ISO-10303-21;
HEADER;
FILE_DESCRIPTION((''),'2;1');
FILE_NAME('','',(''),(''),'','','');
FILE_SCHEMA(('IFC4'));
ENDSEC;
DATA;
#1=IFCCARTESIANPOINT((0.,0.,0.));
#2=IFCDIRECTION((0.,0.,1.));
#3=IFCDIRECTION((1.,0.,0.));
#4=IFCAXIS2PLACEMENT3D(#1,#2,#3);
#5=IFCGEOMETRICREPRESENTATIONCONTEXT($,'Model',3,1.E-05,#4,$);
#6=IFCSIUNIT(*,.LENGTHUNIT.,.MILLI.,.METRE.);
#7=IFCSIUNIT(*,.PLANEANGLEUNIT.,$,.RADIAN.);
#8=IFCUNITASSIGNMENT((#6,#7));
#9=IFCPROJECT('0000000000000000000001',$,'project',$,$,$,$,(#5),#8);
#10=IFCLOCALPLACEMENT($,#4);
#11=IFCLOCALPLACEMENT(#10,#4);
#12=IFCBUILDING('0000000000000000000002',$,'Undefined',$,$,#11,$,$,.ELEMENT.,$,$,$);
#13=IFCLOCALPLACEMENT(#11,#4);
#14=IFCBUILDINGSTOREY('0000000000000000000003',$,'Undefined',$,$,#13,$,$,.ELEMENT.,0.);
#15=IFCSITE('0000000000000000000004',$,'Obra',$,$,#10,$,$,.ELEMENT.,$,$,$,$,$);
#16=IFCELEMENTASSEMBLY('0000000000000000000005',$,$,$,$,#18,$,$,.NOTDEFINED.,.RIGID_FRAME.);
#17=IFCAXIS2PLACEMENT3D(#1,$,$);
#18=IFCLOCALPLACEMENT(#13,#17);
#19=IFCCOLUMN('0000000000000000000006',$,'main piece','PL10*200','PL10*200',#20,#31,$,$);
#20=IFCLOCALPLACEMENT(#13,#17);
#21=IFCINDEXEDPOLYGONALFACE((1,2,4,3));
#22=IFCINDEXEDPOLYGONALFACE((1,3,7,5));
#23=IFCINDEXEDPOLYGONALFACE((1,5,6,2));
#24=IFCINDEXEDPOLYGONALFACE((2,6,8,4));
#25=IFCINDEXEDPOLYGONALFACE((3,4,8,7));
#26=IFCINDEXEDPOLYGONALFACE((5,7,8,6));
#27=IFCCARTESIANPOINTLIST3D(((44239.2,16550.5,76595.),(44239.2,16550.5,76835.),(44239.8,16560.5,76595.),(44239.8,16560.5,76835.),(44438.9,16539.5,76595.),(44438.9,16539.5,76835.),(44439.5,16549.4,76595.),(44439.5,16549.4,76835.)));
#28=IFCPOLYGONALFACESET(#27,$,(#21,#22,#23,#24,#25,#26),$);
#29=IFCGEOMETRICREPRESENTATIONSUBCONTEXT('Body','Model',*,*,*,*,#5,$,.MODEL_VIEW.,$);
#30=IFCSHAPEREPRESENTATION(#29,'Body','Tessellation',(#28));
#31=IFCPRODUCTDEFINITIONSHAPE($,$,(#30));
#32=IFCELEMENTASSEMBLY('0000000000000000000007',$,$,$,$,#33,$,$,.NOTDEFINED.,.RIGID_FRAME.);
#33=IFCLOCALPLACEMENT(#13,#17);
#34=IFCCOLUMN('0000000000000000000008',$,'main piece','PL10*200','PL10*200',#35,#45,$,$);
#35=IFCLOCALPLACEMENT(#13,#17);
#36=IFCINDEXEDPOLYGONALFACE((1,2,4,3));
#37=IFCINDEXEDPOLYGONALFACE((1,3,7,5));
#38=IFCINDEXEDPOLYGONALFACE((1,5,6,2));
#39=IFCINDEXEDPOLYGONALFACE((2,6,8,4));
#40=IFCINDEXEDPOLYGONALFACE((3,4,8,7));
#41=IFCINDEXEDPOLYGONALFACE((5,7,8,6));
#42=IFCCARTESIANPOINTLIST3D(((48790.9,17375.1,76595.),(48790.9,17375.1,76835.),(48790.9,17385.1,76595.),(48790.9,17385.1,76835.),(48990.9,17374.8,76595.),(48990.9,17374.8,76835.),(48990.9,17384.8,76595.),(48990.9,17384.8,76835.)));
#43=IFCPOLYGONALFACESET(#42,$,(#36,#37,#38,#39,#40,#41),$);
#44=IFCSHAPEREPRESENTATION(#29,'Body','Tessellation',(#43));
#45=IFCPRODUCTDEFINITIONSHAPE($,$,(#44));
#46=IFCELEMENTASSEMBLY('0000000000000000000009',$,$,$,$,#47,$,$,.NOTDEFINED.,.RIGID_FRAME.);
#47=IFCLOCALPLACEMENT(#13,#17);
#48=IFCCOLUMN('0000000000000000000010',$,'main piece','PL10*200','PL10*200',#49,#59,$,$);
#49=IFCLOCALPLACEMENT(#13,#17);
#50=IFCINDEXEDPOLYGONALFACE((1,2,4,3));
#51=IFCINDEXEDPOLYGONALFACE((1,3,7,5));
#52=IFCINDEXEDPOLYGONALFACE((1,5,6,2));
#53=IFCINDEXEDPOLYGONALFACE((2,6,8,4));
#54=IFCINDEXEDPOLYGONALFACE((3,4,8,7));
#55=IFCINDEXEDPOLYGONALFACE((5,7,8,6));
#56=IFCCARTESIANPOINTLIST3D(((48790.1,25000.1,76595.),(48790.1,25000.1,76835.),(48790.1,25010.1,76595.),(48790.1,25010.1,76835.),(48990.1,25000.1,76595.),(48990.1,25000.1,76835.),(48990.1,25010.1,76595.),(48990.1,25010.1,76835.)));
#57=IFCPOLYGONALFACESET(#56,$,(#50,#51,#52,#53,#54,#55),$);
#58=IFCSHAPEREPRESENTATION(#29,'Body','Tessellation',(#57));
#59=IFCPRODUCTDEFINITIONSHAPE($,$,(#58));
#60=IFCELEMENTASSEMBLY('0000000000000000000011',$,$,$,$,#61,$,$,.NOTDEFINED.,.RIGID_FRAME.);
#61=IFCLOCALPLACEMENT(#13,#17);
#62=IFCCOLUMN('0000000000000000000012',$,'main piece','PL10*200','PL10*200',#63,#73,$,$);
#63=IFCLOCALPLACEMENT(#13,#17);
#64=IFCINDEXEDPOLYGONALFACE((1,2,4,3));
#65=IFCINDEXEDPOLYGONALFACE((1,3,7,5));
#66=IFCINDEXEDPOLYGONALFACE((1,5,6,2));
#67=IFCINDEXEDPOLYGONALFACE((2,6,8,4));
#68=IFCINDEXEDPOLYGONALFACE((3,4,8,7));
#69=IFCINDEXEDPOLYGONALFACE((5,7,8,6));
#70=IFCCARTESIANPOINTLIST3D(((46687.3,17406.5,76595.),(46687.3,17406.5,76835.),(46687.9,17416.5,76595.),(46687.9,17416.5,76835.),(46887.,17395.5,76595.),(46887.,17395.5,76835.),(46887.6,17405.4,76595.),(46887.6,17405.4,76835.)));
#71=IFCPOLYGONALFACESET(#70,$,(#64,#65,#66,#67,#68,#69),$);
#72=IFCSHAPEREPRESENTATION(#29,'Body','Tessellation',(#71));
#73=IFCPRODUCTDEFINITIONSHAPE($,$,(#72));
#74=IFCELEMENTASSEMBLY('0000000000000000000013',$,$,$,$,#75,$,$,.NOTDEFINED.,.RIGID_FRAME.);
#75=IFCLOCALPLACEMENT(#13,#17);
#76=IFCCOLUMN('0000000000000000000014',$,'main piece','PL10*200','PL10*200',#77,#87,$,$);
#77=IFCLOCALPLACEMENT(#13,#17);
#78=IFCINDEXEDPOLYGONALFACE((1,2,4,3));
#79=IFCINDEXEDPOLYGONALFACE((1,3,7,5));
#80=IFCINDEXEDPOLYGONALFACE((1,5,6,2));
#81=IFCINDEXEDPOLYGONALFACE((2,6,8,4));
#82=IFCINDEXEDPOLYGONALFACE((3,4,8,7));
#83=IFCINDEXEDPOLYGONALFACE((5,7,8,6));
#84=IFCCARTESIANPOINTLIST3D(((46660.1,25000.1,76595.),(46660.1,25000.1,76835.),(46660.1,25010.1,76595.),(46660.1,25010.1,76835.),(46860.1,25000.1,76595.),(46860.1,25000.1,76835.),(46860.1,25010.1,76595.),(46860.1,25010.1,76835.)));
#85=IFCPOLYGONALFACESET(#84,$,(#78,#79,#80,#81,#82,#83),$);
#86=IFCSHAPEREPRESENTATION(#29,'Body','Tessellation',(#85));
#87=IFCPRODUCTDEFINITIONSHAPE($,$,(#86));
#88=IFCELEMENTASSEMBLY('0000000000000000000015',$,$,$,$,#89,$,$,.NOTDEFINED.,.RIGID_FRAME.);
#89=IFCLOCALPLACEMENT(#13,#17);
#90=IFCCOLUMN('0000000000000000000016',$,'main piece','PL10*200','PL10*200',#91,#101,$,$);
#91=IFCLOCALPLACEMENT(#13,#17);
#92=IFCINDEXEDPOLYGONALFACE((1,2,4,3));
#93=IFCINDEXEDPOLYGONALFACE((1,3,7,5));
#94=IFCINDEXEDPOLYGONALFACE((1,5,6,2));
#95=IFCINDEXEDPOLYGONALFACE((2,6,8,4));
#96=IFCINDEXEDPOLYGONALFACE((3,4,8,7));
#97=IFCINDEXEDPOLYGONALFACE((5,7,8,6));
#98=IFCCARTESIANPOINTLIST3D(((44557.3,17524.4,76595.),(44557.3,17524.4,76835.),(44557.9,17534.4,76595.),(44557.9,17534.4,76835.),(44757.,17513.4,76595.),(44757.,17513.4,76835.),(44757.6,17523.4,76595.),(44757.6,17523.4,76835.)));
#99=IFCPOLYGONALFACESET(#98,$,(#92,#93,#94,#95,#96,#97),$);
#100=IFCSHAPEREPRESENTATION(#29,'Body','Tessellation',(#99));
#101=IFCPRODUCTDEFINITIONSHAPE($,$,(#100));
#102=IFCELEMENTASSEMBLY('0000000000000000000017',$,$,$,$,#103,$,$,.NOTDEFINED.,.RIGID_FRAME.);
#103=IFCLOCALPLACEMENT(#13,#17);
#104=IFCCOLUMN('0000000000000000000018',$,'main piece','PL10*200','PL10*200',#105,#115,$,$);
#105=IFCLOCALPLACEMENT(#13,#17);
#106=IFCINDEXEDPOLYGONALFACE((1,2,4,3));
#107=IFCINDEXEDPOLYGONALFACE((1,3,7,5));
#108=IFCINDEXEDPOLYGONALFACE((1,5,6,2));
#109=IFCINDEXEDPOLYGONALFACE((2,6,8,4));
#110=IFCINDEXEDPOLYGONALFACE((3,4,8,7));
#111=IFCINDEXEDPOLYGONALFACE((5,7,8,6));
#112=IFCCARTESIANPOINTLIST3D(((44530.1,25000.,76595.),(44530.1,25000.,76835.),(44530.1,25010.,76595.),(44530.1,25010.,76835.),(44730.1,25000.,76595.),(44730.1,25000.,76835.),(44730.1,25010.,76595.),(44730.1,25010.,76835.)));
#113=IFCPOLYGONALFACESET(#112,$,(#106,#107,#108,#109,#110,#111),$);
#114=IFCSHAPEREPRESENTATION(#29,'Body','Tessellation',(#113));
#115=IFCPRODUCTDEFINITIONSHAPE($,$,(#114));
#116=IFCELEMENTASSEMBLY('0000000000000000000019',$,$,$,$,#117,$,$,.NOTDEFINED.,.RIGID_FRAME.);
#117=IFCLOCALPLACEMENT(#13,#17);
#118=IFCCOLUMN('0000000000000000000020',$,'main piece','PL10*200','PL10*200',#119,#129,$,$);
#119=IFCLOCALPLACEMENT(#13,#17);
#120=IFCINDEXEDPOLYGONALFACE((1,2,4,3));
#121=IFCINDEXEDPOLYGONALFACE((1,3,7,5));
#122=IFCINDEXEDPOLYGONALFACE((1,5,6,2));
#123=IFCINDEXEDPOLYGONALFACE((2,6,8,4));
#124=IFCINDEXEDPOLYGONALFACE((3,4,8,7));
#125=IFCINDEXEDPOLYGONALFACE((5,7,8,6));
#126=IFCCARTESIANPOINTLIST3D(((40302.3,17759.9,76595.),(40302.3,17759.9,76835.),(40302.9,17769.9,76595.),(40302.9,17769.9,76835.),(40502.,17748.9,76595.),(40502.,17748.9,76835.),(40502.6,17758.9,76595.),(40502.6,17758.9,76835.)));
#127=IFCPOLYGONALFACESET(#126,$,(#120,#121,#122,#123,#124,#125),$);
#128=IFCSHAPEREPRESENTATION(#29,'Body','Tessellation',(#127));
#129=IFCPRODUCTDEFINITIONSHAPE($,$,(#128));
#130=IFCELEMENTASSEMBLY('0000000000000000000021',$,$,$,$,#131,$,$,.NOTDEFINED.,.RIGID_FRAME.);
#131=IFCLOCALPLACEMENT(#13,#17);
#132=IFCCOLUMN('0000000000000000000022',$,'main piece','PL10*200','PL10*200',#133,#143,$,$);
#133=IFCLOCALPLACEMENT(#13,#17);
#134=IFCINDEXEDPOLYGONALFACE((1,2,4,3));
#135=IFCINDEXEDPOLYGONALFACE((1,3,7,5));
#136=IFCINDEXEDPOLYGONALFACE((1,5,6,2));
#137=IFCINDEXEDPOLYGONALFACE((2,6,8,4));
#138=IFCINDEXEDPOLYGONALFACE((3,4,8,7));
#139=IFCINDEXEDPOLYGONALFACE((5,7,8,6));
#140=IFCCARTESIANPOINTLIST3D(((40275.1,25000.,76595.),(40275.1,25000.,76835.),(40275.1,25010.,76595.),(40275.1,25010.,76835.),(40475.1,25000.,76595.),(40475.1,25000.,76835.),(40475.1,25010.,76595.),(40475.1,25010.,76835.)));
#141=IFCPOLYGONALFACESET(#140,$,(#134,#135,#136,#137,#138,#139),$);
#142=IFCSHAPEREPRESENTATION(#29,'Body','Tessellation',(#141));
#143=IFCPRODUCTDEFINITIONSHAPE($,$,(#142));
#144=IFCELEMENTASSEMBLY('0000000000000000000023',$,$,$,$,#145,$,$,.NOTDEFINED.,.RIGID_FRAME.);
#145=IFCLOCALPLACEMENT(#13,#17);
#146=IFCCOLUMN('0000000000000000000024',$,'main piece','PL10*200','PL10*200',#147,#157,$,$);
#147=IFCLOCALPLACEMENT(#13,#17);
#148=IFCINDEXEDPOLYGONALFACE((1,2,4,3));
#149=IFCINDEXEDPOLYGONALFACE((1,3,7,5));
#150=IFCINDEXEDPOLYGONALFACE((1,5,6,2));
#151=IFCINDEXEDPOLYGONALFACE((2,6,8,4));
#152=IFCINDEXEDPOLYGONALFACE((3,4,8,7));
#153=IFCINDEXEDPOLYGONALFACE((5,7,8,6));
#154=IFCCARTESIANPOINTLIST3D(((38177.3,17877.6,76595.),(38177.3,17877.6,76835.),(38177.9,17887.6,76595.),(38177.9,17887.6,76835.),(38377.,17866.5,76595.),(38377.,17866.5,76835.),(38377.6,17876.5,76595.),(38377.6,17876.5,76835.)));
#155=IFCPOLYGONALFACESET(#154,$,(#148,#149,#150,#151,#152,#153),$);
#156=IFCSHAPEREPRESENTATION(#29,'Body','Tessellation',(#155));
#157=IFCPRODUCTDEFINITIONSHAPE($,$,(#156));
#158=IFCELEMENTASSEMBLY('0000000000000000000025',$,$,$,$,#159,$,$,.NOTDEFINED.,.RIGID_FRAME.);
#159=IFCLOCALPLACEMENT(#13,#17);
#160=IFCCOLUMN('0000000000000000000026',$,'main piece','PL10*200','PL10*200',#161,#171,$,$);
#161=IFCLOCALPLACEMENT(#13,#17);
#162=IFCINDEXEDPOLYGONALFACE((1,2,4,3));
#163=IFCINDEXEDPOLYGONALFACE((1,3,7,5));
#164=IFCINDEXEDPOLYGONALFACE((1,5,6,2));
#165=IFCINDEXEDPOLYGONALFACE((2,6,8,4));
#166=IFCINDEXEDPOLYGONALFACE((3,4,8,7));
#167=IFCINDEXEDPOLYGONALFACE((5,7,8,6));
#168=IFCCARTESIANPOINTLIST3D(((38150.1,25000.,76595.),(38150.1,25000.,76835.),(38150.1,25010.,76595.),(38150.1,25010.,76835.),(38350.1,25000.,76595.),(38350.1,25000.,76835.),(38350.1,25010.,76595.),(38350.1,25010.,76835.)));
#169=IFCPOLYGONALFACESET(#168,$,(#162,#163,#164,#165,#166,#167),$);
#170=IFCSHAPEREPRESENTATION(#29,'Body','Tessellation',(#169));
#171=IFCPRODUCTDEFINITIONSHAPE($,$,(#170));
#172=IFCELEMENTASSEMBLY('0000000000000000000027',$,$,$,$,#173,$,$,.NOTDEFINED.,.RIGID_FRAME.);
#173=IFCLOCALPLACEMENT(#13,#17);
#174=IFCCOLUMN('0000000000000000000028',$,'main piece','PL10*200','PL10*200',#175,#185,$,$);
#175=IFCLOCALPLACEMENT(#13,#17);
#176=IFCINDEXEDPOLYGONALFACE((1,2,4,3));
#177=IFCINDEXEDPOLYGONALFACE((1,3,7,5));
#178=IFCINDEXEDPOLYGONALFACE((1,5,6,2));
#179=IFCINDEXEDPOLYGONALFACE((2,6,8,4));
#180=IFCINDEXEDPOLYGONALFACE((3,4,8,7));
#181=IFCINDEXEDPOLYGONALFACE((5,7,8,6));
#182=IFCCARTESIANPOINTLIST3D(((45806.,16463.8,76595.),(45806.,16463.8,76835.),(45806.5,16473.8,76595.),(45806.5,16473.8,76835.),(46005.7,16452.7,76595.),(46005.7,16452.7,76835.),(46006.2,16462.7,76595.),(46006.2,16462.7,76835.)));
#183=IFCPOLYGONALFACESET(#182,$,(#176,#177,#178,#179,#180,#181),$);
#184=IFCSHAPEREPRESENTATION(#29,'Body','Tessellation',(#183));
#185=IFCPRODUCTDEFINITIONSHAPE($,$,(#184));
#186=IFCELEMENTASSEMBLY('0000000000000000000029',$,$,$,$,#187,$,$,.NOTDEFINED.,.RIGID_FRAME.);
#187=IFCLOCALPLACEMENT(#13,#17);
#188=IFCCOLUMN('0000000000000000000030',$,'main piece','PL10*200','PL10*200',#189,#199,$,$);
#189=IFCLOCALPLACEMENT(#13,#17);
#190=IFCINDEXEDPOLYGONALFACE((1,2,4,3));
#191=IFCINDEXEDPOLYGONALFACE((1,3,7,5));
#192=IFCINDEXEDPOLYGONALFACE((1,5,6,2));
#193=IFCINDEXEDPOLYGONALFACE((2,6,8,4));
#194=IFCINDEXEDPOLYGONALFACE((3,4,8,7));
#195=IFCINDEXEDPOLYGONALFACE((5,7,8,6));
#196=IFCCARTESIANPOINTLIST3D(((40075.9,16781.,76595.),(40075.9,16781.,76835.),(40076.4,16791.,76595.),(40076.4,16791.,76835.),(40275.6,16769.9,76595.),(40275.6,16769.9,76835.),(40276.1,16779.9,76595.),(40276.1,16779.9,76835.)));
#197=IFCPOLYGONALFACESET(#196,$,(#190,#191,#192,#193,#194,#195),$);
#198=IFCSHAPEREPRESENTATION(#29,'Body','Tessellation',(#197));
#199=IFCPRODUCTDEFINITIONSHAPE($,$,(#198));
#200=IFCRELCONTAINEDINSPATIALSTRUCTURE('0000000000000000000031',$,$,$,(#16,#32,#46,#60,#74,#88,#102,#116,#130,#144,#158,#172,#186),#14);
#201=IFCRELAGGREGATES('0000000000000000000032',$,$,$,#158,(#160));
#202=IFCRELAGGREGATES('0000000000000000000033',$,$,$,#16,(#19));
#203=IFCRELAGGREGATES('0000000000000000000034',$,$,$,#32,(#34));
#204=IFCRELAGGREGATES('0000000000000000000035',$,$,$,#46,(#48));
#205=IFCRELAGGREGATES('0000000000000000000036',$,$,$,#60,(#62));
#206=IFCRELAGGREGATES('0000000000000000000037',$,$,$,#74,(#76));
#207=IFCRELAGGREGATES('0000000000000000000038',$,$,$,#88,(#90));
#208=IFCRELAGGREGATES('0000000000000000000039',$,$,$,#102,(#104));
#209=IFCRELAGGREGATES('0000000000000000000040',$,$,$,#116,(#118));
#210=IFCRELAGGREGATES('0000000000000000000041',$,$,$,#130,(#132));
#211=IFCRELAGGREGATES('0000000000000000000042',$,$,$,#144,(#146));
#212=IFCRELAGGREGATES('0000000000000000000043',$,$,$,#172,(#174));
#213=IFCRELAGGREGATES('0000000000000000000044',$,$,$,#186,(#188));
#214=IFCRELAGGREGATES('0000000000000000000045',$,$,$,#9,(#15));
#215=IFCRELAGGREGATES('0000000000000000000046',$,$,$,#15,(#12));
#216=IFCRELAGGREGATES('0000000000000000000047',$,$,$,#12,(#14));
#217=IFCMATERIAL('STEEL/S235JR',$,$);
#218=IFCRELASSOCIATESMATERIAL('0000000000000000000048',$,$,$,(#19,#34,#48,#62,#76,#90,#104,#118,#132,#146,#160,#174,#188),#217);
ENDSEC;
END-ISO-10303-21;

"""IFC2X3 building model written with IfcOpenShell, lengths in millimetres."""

from ifc_helpers import new_model, si_unit, frame, origin_with_axes, origin_2d_with_axis, place, context, subcontext, project, spatial, rectangle, extrude, material, element, aggregate, save


model = new_model("IFC2X3")

# Units and contexts
model_context = context("Model", 3, precision=1e-05, world=origin_with_axes())
body_context = subcontext(model_context, "Body", "Model", "MODEL_VIEW")
ifc_project = project(units=[si_unit("LENGTHUNIT", "METRE", prefix="MILLI"), si_unit("PLANEANGLEUNIT", "RADIAN")], contexts=[model_context])

# Site, building, storey
site_placement = place(None, origin_with_axes())
site = spatial("IfcSite", under=ifc_project, at=site_placement, Name="Obra", CompositionType="ELEMENT")
building_placement = place(site_placement, origin_with_axes())
building = spatial("IfcBuilding", under=site, at=building_placement, Name="Undefined", CompositionType="ELEMENT")
storey_placement = place(building_placement, origin_with_axes())
storey = spatial("IfcBuildingStorey", under=building, at=storey_placement, Name="Undefined", CompositionType="ELEMENT", Elevation=0.0)

# Element assemblies, columns
assembly_1_placement = place(storey_placement, origin_with_axes())
assembly_1 = element("IfcElementAssembly", 1, at=assembly_1_placement, inside=storey, AssemblyPlace="NOTDEFINED", PredefinedType="RIGID_FRAME")
ifc_material_1 = material(Name="STEEL/S235JR")
column_1_placement = place(assembly_1_placement, frame((44339.4, 16550.0, 76595.0), z_axis=(0.0, 0.0, 1.0), x_axis=(-0.998472, 0.055268, 0.0)))
column_1 = element("IfcColumn", 2, at=column_1_placement, material=ifc_material_1, Name="main piece", Description="PL10*200", ObjectType="PL10*200", context=body_context, shape_type="SweptSolid", body=[
    extrude(rectangle(XDim=10.0, YDim=200.0, at=origin_2d_with_axis()), frame((0.0, 0.0, 240.0), z_axis=(0.0, 0.0, -1.0), x_axis=(0.0, 1.0, 0.0)), (0.0, 0.0, 1.0), 240.0),
])
assembly_2_placement = place(storey_placement, origin_with_axes())
assembly_2 = element("IfcElementAssembly", 3, at=assembly_2_placement, inside=storey, AssemblyPlace="NOTDEFINED", PredefinedType="RIGID_FRAME")
column_2_placement = place(assembly_2_placement, frame((48890.9, 17380.0, 76595.0), z_axis=(0.0, 0.0, 1.0), x_axis=(0.999999, -0.001649, 0.0)))
column_2 = element("IfcColumn", 4, at=column_2_placement, material=ifc_material_1, Name="main piece", Description="PL10*200", ObjectType="PL10*200", context=body_context, shape_type="SweptSolid", body=[
    extrude(rectangle(XDim=10.0, YDim=200.0, at=origin_2d_with_axis()), frame((0.0, 0.0, 240.0), z_axis=(0.0, 0.0, -1.0), x_axis=(0.0, 1.0, 0.0)), (0.0, 0.0, 1.0), 240.0),
])
assembly_3_placement = place(storey_placement, origin_with_axes())
assembly_3 = element("IfcElementAssembly", 5, at=assembly_3_placement, inside=storey, AssemblyPlace="NOTDEFINED", PredefinedType="RIGID_FRAME")
column_3_placement = place(assembly_3_placement, frame((48890.1, 25005.1, 76595.0), z_axis=(0.0, 0.0, 1.0), x_axis=(-1.0, -0.000002, 0.0)))
column_3 = element("IfcColumn", 6, at=column_3_placement, material=ifc_material_1, Name="main piece", Description="PL10*200", ObjectType="PL10*200", context=body_context, shape_type="SweptSolid", body=[
    extrude(rectangle(XDim=10.0, YDim=200.0, at=origin_2d_with_axis()), frame((0.0, 0.0, 240.0), z_axis=(0.0, 0.0, -1.0), x_axis=(0.0, 1.0, 0.0)), (0.0, 0.0, 1.0), 240.0),
])
assembly_4_placement = place(storey_placement, origin_with_axes())
assembly_4 = element("IfcElementAssembly", 7, at=assembly_4_placement, inside=storey, AssemblyPlace="NOTDEFINED", PredefinedType="RIGID_FRAME")
column_4_placement = place(assembly_4_placement, frame((46787.4, 17406.0, 76595.0), z_axis=(0.0, 0.0, 1.0), x_axis=(0.998472, -0.055268, 0.0)))
column_4 = element("IfcColumn", 8, at=column_4_placement, material=ifc_material_1, Name="main piece", Description="PL10*200", ObjectType="PL10*200", context=body_context, shape_type="SweptSolid", body=[
    extrude(rectangle(XDim=10.0, YDim=200.0, at=origin_2d_with_axis()), frame((0.0, 0.0, 240.0), z_axis=(0.0, 0.0, -1.0), x_axis=(0.0, 1.0, 0.0)), (0.0, 0.0, 1.0), 240.0),
])
assembly_5_placement = place(storey_placement, origin_with_axes())
assembly_5 = element("IfcElementAssembly", 9, at=assembly_5_placement, inside=storey, AssemblyPlace="NOTDEFINED", PredefinedType="RIGID_FRAME")
column_5_placement = place(assembly_5_placement, frame((46760.1, 25005.1, 76595.0), z_axis=(0.0, 0.0, 1.0), x_axis=(-1.0, -0.000002, 0.0)))
column_5 = element("IfcColumn", 10, at=column_5_placement, material=ifc_material_1, Name="main piece", Description="PL10*200", ObjectType="PL10*200", context=body_context, shape_type="SweptSolid", body=[
    extrude(rectangle(XDim=10.0, YDim=200.0, at=origin_2d_with_axis()), frame((0.0, 0.0, 240.0), z_axis=(0.0, 0.0, -1.0), x_axis=(0.0, 1.0, 0.0)), (0.0, 0.0, 1.0), 240.0),
])
assembly_6_placement = place(storey_placement, origin_with_axes())
assembly_6 = element("IfcElementAssembly", 11, at=assembly_6_placement, inside=storey, AssemblyPlace="NOTDEFINED", PredefinedType="RIGID_FRAME")
column_6_placement = place(assembly_6_placement, frame((44657.4, 17523.9, 76595.0), z_axis=(0.0, 0.0, 1.0), x_axis=(0.998472, -0.055268, 0.0)))
column_6 = element("IfcColumn", 12, at=column_6_placement, material=ifc_material_1, Name="main piece", Description="PL10*200", ObjectType="PL10*200", context=body_context, shape_type="SweptSolid", body=[
    extrude(rectangle(XDim=10.0, YDim=200.0, at=origin_2d_with_axis()), frame((0.0, 0.0, 240.0), z_axis=(0.0, 0.0, -1.0), x_axis=(0.0, 1.0, 0.0)), (0.0, 0.0, 1.0), 240.0),
])
assembly_7_placement = place(storey_placement, origin_with_axes())
assembly_7 = element("IfcElementAssembly", 13, at=assembly_7_placement, inside=storey, AssemblyPlace="NOTDEFINED", PredefinedType="RIGID_FRAME")
column_7_placement = place(assembly_7_placement, frame((44630.1, 25005.0, 76595.0), z_axis=(0.0, 0.0, 1.0), x_axis=(-1.0, -0.000002, 0.0)))
column_7 = element("IfcColumn", 14, at=column_7_placement, material=ifc_material_1, Name="main piece", Description="PL10*200", ObjectType="PL10*200", context=body_context, shape_type="SweptSolid", body=[
    extrude(rectangle(XDim=10.0, YDim=200.0, at=origin_2d_with_axis()), frame((0.0, 0.0, 240.0), z_axis=(0.0, 0.0, -1.0), x_axis=(0.0, 1.0, 0.0)), (0.0, 0.0, 1.0), 240.0),
])
assembly_8_placement = place(storey_placement, origin_with_axes())
assembly_8 = element("IfcElementAssembly", 15, at=assembly_8_placement, inside=storey, AssemblyPlace="NOTDEFINED", PredefinedType="RIGID_FRAME")
column_8_placement = place(assembly_8_placement, frame((40402.4, 17759.4, 76595.0), z_axis=(0.0, 0.0, 1.0), x_axis=(0.998472, -0.055268, 0.0)))
column_8 = element("IfcColumn", 16, at=column_8_placement, material=ifc_material_1, Name="main piece", Description="PL10*200", ObjectType="PL10*200", context=body_context, shape_type="SweptSolid", body=[
    extrude(rectangle(XDim=10.0, YDim=200.0, at=origin_2d_with_axis()), frame((0.0, 0.0, 240.0), z_axis=(0.0, 0.0, -1.0), x_axis=(0.0, 1.0, 0.0)), (0.0, 0.0, 1.0), 240.0),
])
assembly_9_placement = place(storey_placement, origin_with_axes())
assembly_9 = element("IfcElementAssembly", 17, at=assembly_9_placement, inside=storey, AssemblyPlace="NOTDEFINED", PredefinedType="RIGID_FRAME")
column_9_placement = place(assembly_9_placement, frame((40375.1, 25005.0, 76595.0), z_axis=(0.0, 0.0, 1.0), x_axis=(-1.0, -0.000002, 0.0)))
column_9 = element("IfcColumn", 18, at=column_9_placement, material=ifc_material_1, Name="main piece", Description="PL10*200", ObjectType="PL10*200", context=body_context, shape_type="SweptSolid", body=[
    extrude(rectangle(XDim=10.0, YDim=200.0, at=origin_2d_with_axis()), frame((0.0, 0.0, 240.0), z_axis=(0.0, 0.0, -1.0), x_axis=(0.0, 1.0, 0.0)), (0.0, 0.0, 1.0), 240.0),
])
assembly_10_placement = place(storey_placement, origin_with_axes())
assembly_10 = element("IfcElementAssembly", 19, at=assembly_10_placement, inside=storey, AssemblyPlace="NOTDEFINED", PredefinedType="RIGID_FRAME")
column_10_placement = place(assembly_10_placement, frame((38277.4, 17877.0, 76595.0), z_axis=(0.0, 0.0, 1.0), x_axis=(0.998472, -0.055268, 0.0)))
column_10 = element("IfcColumn", 20, at=column_10_placement, material=ifc_material_1, Name="main piece", Description="PL10*200", ObjectType="PL10*200", context=body_context, shape_type="SweptSolid", body=[
    extrude(rectangle(XDim=10.0, YDim=200.0, at=origin_2d_with_axis()), frame((0.0, 0.0, 240.0), z_axis=(0.0, 0.0, -1.0), x_axis=(0.0, 1.0, 0.0)), (0.0, 0.0, 1.0), 240.0),
])
assembly_11_placement = place(storey_placement, origin_with_axes())
assembly_11 = element("IfcElementAssembly", 21, at=assembly_11_placement, inside=storey, AssemblyPlace="NOTDEFINED", PredefinedType="RIGID_FRAME")
column_11_placement = place(assembly_11_placement, frame((38250.1, 25005.0, 76595.0), z_axis=(0.0, 0.0, 1.0), x_axis=(-1.0, -0.000002, 0.0)))
column_11 = element("IfcColumn", 22, at=column_11_placement, material=ifc_material_1, Name="main piece", Description="PL10*200", ObjectType="PL10*200", context=body_context, shape_type="SweptSolid", body=[
    extrude(rectangle(XDim=10.0, YDim=200.0, at=origin_2d_with_axis()), frame((0.0, 0.0, 240.0), z_axis=(0.0, 0.0, -1.0), x_axis=(0.0, 1.0, 0.0)), (0.0, 0.0, 1.0), 240.0),
])
aggregate(assembly_11, [column_11])
assembly_12_placement = place(storey_placement, origin_with_axes())
assembly_12 = element("IfcElementAssembly", 23, at=assembly_12_placement, inside=storey, AssemblyPlace="NOTDEFINED", PredefinedType="RIGID_FRAME")
column_12_placement = place(assembly_12_placement, frame((45906.1, 16463.3, 76595.0), z_axis=(0.0, 0.0, 1.0), x_axis=(-0.998472, 0.055268, 0.0)))
column_12 = element("IfcColumn", 24, at=column_12_placement, material=ifc_material_1, Name="main piece", Description="PL10*200", ObjectType="PL10*200", context=body_context, shape_type="SweptSolid", body=[
    extrude(rectangle(XDim=10.0, YDim=200.0, at=origin_2d_with_axis()), frame((0.0, 0.0, 240.0), z_axis=(0.0, 0.0, -1.0), x_axis=(0.0, 1.0, 0.0)), (0.0, 0.0, 1.0), 240.0),
])
assembly_13_placement = place(storey_placement, origin_with_axes())
assembly_13 = element("IfcElementAssembly", 25, at=assembly_13_placement, inside=storey, AssemblyPlace="NOTDEFINED", PredefinedType="RIGID_FRAME")
column_13_placement = place(assembly_13_placement, frame((40176.0, 16780.4, 76595.0), z_axis=(0.0, 0.0, 1.0), x_axis=(-0.998472, 0.055268, 0.0)))
column_13 = element("IfcColumn", 26, at=column_13_placement, material=ifc_material_1, Name="main piece", Description="PL10*200", ObjectType="PL10*200", context=body_context, shape_type="SweptSolid", body=[
    extrude(rectangle(XDim=10.0, YDim=200.0, at=origin_2d_with_axis()), frame((0.0, 0.0, 240.0), z_axis=(0.0, 0.0, -1.0), x_axis=(0.0, 1.0, 0.0)), (0.0, 0.0, 1.0), 240.0),
])

aggregate(assembly_1, [column_1])
aggregate(assembly_2, [column_2])
aggregate(assembly_3, [column_3])
aggregate(assembly_4, [column_4])
aggregate(assembly_5, [column_5])
aggregate(assembly_6, [column_6])
aggregate(assembly_7, [column_7])
aggregate(assembly_8, [column_8])
aggregate(assembly_9, [column_9])
aggregate(assembly_10, [column_10])
aggregate(assembly_12, [column_12])
aggregate(assembly_13, [column_13])

save(model, "model.ifc")
